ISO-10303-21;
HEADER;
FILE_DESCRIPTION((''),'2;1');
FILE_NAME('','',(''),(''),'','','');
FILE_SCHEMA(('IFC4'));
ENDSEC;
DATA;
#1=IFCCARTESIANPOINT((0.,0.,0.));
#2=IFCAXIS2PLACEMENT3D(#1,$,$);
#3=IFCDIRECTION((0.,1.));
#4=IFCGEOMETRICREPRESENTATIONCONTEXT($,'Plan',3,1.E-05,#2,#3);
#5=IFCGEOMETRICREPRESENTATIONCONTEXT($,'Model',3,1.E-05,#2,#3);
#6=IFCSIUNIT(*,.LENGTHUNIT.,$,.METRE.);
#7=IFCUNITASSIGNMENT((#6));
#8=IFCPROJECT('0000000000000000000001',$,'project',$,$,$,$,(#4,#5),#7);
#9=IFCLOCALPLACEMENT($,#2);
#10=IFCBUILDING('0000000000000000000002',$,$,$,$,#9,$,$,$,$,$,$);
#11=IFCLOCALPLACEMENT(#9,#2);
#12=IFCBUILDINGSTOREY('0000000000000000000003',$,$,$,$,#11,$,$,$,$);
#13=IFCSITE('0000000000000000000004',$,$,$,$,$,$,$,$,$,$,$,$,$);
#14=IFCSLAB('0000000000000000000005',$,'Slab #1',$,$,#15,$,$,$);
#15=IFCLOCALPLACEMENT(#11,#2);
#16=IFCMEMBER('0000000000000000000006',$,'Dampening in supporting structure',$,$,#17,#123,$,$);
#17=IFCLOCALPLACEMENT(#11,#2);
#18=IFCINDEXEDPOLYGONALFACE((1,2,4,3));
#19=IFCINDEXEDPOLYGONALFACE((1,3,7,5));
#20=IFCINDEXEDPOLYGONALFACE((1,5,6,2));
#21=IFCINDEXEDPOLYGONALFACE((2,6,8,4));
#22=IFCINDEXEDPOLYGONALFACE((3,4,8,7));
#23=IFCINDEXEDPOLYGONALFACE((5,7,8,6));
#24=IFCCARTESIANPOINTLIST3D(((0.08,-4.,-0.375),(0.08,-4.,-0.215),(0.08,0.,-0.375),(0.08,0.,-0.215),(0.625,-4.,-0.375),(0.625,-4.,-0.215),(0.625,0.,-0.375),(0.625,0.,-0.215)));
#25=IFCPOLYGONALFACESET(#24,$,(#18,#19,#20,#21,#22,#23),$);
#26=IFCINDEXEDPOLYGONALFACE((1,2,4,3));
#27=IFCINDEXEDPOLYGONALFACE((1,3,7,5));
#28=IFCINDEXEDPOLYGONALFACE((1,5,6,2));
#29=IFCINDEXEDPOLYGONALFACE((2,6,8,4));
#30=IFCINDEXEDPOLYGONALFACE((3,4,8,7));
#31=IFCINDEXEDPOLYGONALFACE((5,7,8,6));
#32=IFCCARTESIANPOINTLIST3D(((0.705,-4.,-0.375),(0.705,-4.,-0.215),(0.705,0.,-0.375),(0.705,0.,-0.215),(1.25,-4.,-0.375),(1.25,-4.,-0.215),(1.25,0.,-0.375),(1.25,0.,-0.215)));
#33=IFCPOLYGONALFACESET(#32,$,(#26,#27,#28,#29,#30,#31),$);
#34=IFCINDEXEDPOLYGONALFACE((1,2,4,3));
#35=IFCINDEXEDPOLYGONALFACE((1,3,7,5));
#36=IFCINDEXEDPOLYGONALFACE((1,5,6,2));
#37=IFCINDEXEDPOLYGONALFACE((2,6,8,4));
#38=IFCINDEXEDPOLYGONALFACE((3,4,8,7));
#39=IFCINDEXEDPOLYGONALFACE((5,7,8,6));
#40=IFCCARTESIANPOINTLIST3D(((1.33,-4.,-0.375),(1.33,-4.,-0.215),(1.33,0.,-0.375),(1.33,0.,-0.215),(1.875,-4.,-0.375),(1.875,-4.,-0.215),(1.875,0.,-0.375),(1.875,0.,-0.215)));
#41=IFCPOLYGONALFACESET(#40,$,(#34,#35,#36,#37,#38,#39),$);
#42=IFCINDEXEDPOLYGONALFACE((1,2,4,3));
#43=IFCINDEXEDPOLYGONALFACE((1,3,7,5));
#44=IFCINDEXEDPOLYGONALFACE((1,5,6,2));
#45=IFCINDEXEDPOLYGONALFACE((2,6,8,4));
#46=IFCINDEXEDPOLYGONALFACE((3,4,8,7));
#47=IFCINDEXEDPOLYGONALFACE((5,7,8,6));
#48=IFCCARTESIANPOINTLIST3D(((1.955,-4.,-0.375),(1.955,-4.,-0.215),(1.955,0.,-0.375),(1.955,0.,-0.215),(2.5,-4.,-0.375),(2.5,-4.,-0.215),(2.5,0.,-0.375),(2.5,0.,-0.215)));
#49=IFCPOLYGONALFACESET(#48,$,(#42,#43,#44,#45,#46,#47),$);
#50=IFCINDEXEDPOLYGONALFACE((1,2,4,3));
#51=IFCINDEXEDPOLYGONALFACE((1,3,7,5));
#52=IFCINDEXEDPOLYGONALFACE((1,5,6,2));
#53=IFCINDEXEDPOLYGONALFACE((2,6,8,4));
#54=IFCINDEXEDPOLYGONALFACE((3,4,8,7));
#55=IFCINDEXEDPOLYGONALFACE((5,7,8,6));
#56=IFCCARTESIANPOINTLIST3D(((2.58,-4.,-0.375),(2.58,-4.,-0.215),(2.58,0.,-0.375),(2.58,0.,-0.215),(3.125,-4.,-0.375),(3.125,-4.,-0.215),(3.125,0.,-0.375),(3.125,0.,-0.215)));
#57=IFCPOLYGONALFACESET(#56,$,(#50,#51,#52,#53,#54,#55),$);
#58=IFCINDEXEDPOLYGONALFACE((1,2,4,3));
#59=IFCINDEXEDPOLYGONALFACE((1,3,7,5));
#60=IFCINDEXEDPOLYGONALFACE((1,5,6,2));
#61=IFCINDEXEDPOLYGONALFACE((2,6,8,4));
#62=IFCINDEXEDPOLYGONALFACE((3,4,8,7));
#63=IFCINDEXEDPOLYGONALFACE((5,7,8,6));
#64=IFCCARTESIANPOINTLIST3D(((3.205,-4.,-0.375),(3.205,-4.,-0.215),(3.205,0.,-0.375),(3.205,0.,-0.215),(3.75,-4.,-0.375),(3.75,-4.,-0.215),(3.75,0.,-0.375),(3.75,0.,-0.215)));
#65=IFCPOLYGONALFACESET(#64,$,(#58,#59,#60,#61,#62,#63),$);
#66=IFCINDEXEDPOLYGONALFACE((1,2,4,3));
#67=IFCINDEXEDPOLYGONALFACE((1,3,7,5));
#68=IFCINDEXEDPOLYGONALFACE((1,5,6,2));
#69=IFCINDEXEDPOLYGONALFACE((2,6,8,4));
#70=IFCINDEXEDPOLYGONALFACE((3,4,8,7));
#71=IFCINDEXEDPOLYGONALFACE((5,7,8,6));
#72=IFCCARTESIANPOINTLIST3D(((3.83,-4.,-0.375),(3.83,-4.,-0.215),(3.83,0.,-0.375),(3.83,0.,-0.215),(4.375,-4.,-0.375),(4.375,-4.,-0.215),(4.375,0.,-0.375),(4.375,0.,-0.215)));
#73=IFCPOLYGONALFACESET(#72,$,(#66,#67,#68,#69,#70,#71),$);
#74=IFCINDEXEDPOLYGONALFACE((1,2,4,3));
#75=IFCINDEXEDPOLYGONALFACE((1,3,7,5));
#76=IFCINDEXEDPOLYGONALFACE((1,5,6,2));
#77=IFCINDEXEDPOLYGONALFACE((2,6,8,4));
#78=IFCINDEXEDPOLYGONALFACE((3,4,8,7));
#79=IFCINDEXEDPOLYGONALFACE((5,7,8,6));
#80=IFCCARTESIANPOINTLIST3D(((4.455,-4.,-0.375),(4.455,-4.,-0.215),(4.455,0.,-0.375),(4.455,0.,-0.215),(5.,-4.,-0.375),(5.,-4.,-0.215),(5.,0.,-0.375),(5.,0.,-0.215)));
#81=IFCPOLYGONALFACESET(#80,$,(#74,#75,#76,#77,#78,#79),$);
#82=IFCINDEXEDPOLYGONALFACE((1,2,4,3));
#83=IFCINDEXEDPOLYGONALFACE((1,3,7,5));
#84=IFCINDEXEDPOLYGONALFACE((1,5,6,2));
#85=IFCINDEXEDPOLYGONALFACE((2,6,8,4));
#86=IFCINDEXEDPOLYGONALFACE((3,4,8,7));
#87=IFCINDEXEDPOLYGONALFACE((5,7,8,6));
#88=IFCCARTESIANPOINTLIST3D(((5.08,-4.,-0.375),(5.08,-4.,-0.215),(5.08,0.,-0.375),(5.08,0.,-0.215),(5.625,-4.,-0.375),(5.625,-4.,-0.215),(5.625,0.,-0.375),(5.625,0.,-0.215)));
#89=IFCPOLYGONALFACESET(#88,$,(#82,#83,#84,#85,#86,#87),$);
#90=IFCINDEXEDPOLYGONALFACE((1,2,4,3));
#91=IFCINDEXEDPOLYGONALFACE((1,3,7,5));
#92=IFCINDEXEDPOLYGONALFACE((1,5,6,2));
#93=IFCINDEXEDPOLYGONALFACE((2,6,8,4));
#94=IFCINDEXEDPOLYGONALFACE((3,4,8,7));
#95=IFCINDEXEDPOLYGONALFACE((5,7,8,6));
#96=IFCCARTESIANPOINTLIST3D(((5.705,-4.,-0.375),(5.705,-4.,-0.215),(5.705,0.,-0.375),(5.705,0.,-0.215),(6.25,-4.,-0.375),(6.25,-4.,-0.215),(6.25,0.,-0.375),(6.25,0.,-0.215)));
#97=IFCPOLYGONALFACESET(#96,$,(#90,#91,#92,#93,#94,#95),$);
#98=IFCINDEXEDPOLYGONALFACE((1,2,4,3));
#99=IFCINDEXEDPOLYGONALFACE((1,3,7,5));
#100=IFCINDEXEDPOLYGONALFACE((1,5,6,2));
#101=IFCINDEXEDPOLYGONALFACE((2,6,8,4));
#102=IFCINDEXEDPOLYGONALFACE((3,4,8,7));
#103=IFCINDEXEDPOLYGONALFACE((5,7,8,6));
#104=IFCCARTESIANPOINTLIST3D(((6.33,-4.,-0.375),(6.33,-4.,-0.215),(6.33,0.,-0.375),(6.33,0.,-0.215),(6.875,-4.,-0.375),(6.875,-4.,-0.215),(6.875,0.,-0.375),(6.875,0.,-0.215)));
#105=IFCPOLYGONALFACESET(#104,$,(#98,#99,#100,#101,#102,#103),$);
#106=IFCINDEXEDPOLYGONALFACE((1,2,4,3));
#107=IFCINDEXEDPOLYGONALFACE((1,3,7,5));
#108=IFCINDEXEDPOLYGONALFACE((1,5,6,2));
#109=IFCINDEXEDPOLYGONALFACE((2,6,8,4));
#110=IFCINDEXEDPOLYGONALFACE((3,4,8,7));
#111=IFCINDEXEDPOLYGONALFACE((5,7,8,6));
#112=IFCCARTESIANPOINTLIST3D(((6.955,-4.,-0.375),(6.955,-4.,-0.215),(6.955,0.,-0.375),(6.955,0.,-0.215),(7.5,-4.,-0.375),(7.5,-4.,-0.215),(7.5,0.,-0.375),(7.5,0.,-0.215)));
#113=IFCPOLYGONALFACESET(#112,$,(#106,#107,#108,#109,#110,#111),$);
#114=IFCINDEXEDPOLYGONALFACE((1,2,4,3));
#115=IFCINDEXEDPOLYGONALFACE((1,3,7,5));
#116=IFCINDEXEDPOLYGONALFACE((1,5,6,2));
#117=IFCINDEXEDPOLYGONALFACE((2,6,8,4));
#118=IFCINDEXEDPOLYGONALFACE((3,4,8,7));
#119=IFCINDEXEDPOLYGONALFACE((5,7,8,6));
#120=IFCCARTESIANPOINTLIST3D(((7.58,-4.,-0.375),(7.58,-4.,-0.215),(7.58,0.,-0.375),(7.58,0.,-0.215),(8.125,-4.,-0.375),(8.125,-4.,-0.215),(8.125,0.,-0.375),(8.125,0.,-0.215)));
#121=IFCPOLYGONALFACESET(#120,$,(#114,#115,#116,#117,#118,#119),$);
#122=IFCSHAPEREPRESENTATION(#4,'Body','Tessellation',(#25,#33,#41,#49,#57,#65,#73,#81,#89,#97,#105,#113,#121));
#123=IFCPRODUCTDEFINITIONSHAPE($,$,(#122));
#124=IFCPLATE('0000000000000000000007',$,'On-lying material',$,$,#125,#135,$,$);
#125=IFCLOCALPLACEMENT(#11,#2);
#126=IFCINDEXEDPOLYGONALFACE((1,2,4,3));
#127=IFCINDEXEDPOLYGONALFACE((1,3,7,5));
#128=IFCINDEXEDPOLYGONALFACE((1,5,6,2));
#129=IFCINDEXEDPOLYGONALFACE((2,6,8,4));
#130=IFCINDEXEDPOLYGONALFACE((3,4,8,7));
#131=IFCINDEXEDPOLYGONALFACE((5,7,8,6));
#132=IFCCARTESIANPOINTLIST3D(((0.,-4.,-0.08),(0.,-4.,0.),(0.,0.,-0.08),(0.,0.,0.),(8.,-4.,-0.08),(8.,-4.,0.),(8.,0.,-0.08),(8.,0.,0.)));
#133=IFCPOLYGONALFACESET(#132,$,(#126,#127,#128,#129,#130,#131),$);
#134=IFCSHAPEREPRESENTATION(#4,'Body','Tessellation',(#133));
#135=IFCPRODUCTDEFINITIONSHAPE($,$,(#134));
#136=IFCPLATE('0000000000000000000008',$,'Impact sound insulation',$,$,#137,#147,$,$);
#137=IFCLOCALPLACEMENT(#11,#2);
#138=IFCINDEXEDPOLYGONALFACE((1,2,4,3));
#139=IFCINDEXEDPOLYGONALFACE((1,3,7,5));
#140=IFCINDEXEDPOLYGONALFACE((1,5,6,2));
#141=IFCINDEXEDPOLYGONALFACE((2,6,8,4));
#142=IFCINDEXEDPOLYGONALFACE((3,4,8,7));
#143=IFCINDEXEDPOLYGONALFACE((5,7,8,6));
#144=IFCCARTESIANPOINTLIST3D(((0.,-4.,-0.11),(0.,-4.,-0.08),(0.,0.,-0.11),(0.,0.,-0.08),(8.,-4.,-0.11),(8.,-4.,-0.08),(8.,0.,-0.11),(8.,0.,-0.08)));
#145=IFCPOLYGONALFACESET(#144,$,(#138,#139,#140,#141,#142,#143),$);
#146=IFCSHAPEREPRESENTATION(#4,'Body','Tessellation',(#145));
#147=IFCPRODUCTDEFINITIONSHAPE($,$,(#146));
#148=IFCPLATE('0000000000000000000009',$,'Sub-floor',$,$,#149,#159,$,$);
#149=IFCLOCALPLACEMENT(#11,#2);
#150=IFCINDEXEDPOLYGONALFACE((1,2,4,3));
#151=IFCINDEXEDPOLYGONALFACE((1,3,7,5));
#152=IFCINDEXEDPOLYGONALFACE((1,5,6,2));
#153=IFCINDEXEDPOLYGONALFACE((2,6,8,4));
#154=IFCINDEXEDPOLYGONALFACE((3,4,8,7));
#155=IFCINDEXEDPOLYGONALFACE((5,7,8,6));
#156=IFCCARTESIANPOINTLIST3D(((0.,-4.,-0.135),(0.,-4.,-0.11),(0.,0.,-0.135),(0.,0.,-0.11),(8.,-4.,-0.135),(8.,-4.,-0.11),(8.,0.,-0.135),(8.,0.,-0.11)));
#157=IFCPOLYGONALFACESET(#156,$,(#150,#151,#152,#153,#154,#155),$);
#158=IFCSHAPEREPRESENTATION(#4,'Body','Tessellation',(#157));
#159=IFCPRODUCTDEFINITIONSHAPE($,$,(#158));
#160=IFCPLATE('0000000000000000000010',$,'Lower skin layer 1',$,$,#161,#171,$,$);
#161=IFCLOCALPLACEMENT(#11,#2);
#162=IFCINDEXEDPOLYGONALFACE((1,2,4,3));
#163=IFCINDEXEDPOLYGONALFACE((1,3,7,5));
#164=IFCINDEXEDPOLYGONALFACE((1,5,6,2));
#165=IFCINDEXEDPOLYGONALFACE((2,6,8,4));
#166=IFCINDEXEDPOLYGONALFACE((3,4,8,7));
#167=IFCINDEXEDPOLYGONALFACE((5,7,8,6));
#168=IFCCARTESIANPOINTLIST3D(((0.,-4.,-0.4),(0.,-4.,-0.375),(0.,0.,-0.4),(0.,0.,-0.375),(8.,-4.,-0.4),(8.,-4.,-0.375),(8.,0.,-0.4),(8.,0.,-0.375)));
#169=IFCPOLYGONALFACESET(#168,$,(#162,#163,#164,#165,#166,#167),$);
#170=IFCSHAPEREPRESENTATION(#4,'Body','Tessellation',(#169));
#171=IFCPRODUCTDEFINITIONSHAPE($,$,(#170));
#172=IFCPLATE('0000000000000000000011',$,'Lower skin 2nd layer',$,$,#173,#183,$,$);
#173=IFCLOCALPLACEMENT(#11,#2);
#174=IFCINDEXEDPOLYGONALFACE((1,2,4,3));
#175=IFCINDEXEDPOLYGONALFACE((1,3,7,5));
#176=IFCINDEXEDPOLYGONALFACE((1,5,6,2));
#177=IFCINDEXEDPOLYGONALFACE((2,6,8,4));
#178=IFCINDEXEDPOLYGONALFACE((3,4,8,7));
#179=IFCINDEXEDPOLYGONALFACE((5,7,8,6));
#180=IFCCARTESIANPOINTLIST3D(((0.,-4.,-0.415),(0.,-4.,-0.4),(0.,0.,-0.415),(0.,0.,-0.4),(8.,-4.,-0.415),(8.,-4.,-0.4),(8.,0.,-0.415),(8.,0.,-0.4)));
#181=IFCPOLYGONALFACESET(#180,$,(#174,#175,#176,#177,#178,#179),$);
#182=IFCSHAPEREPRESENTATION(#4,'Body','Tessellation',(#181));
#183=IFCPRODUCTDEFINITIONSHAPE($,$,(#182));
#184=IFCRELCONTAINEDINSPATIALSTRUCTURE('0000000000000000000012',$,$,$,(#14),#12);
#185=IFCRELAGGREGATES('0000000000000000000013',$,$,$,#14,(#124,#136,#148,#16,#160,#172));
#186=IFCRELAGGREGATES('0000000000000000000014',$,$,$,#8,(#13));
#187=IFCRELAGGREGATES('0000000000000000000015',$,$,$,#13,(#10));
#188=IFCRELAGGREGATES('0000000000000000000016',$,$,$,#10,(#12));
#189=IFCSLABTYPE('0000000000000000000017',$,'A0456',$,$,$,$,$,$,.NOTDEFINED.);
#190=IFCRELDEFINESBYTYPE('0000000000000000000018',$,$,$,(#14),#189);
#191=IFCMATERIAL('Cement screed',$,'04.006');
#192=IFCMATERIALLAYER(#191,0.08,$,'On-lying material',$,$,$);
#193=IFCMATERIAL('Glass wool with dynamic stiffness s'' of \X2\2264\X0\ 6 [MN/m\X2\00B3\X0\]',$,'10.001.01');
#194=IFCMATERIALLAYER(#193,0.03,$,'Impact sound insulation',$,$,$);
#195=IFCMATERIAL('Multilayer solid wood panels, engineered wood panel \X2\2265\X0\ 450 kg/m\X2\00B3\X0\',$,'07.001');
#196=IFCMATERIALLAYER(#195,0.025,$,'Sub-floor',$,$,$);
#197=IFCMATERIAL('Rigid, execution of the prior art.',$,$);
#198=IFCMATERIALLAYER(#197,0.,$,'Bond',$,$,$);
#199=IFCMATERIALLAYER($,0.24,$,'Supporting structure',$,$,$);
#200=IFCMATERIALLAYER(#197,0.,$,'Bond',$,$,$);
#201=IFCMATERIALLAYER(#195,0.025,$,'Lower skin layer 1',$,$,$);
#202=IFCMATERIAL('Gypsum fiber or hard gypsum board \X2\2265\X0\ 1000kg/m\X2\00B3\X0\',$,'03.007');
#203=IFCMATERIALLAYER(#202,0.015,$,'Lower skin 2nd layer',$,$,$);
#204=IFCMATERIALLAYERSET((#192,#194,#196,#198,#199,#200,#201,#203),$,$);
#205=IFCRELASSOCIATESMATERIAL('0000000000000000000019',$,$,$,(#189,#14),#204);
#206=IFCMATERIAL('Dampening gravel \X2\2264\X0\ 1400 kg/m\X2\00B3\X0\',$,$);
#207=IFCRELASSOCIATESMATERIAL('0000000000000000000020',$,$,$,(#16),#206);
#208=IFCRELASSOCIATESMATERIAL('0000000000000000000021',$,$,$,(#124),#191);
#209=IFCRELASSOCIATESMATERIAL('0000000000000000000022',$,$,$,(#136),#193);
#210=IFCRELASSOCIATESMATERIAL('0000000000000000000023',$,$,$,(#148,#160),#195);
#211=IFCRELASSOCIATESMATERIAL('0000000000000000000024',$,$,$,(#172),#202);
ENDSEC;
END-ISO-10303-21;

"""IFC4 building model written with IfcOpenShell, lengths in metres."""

from ifc_helpers import new_model, si_unit, direction, frame, frame_2d, origin, origin_with_axes, place, context, project, spatial, rectangle, extrude, material, layer, layer_set, type_object, element, aggregate, save


model = new_model("IFC4")

# Units and contexts
plan_context = context("Plan", 3, precision=1e-05, world=origin(), true_north=direction((0.0, 1.0)))
model_context = context("Model", 3, precision=1e-05, world=origin(), true_north=direction((0.0, 1.0)))
ifc_project = project(units=[si_unit("LENGTHUNIT", "METRE")], contexts=[plan_context, model_context])

# Site, building, storey
site = spatial("IfcSite", under=ifc_project)
building_placement = place(None, origin())
building = spatial("IfcBuilding", under=site, at=building_placement)
storey_placement = place(building_placement, origin())
storey = spatial("IfcBuildingStorey", under=building, at=storey_placement)

# Slab, member, plates
ifc_material_1 = material(Name="Cement screed", Category="04.006")
ifc_layer_1 = layer(ifc_material_1, 0.08, Name="On-lying material")
ifc_material_2 = material(Name="Glass wool with dynamic stiffness s' of ≤ 6 [MN/m³]", Category="10.001.01")
ifc_layer_2 = layer(ifc_material_2, 0.03, Name="Impact sound insulation")
ifc_material_3 = material(Name="Multilayer solid wood panels, engineered wood panel ≥ 450 kg/m³", Category="07.001")
ifc_layer_3 = layer(ifc_material_3, 0.025, Name="Sub-floor")
ifc_material_4 = material(Name="Rigid, execution of the prior art.")
ifc_layer_4 = layer(ifc_material_4, 0.0, Name="Bond")
ifc_layer_5 = layer(None, 0.24, Name="Supporting structure")
ifc_layer_6 = layer(ifc_material_4, 0.0, Name="Bond")
ifc_layer_7 = layer(ifc_material_3, 0.025, Name="Lower skin layer 1")
ifc_material_5 = material(Name="Gypsum fiber or hard gypsum board ≥ 1000kg/m³", Category="03.007")
ifc_layer_8 = layer(ifc_material_5, 0.015, Name="Lower skin 2nd layer")
ifc_layer_set = layer_set([ifc_layer_1, ifc_layer_2, ifc_layer_3, ifc_layer_4, ifc_layer_5, ifc_layer_6, ifc_layer_7, ifc_layer_8])
slab_type = type_object("IfcSlabType", Name="A0456", PredefinedType="NOTDEFINED", material=ifc_layer_set)
slab_placement = place(None, frame((0.0, 0.0, 0.0), z_axis=(0.0, 0.0, -1.0), x_axis=(1.0, 0.0, 0.0)))
slab = element("IfcSlab", 1, at=slab_placement, inside=storey, type_object=slab_type, material=ifc_layer_set, Name="Slab #1")
ifc_material_6 = material(Name="Dampening gravel ≤ 1400 kg/m³")
member_1_placement = place(slab_placement, origin())
member_1 = element("IfcMember", 2, at=member_1_placement, material=ifc_material_6, Name="Dampening in supporting structure", context=plan_context, shape_type="SweptSolid", body=[
    extrude(rectangle(XDim=0.545, YDim=0.16, at=frame_2d((0.2725, 0.08), x_axis=(1.0, 0.0))), frame((0.08, 4.0, 0.215), z_axis=(0.0, -1.0, 0.0), x_axis=(1.0, 0.0, 0.0)), (0.0, 0.0, 1.0), 4.0),
    extrude(rectangle(XDim=0.545, YDim=0.16, at=frame_2d((0.2725, 0.08), x_axis=(1.0, 0.0))), frame((0.705, 4.0, 0.215), z_axis=(0.0, -1.0, 0.0), x_axis=(1.0, 0.0, 0.0)), (0.0, 0.0, 1.0), 4.0),
    extrude(rectangle(XDim=0.545, YDim=0.16, at=frame_2d((0.2725, 0.08), x_axis=(1.0, 0.0))), frame((1.33, 4.0, 0.215), z_axis=(0.0, -1.0, 0.0), x_axis=(1.0, 0.0, 0.0)), (0.0, 0.0, 1.0), 4.0),
    extrude(rectangle(XDim=0.545, YDim=0.16, at=frame_2d((0.2725, 0.08), x_axis=(1.0, 0.0))), frame((1.955, 4.0, 0.215), z_axis=(0.0, -1.0, 0.0), x_axis=(1.0, 0.0, 0.0)), (0.0, 0.0, 1.0), 4.0),
    extrude(rectangle(XDim=0.545, YDim=0.16, at=frame_2d((0.2725, 0.08), x_axis=(1.0, 0.0))), frame((2.58, 4.0, 0.215), z_axis=(0.0, -1.0, 0.0), x_axis=(1.0, 0.0, 0.0)), (0.0, 0.0, 1.0), 4.0),
    extrude(rectangle(XDim=0.545, YDim=0.16, at=frame_2d((0.2725, 0.08), x_axis=(1.0, 0.0))), frame((3.205, 4.0, 0.215), z_axis=(0.0, -1.0, 0.0), x_axis=(1.0, 0.0, 0.0)), (0.0, 0.0, 1.0), 4.0),
    extrude(rectangle(XDim=0.545, YDim=0.16, at=frame_2d((0.2725, 0.08), x_axis=(1.0, 0.0))), frame((3.83, 4.0, 0.215), z_axis=(0.0, -1.0, 0.0), x_axis=(1.0, 0.0, 0.0)), (0.0, 0.0, 1.0), 4.0),
    extrude(rectangle(XDim=0.545, YDim=0.16, at=frame_2d((0.2725, 0.08), x_axis=(1.0, 0.0))), frame((4.455, 4.0, 0.215), z_axis=(0.0, -1.0, 0.0), x_axis=(1.0, 0.0, 0.0)), (0.0, 0.0, 1.0), 4.0),
    extrude(rectangle(XDim=0.545, YDim=0.16, at=frame_2d((0.2725, 0.08), x_axis=(1.0, 0.0))), frame((5.08, 4.0, 0.215), z_axis=(0.0, -1.0, 0.0), x_axis=(1.0, 0.0, 0.0)), (0.0, 0.0, 1.0), 4.0),
    extrude(rectangle(XDim=0.545, YDim=0.16, at=frame_2d((0.2725, 0.08), x_axis=(1.0, 0.0))), frame((5.705, 4.0, 0.215), z_axis=(0.0, -1.0, 0.0), x_axis=(1.0, 0.0, 0.0)), (0.0, 0.0, 1.0), 4.0),
    extrude(rectangle(XDim=0.545, YDim=0.16, at=frame_2d((0.2725, 0.08), x_axis=(1.0, 0.0))), frame((6.33, 4.0, 0.215), z_axis=(0.0, -1.0, 0.0), x_axis=(1.0, 0.0, 0.0)), (0.0, 0.0, 1.0), 4.0),
    extrude(rectangle(XDim=0.545, YDim=0.16, at=frame_2d((0.2725, 0.08), x_axis=(1.0, 0.0))), frame((6.955, 4.0, 0.215), z_axis=(0.0, -1.0, 0.0), x_axis=(1.0, 0.0, 0.0)), (0.0, 0.0, 1.0), 4.0),
    extrude(rectangle(XDim=0.545, YDim=0.16, at=frame_2d((0.2725, 0.08), x_axis=(1.0, 0.0))), frame((7.58, 4.0, 0.215), z_axis=(0.0, -1.0, 0.0), x_axis=(1.0, 0.0, 0.0)), (0.0, 0.0, 1.0), 4.0),
])
plate_1_placement = place(slab_placement, origin())
plate_1 = element("IfcPlate", 3, at=plate_1_placement, material=ifc_material_1, Name="On-lying material", context=plan_context, shape_type="SweptSolid", body=[
    extrude(rectangle(XDim=8.0, YDim=4.0, at=frame_2d((4.0, 2.0), x_axis=(1.0, 0.0))), origin_with_axes(), (0.0, 0.0, 1.0), 0.08),
])
plate_2_placement = place(slab_placement, origin())
plate_2 = element("IfcPlate", 4, at=plate_2_placement, material=ifc_material_2, Name="Impact sound insulation", context=plan_context, shape_type="SweptSolid", body=[
    extrude(rectangle(XDim=8.0, YDim=4.0, at=frame_2d((4.0, 2.0), x_axis=(1.0, 0.0))), frame((0.0, 0.0, 0.08), z_axis=(0.0, 0.0, 1.0), x_axis=(1.0, 0.0, 0.0)), (0.0, 0.0, 1.0), 0.03),
])
plate_3_placement = place(slab_placement, origin())
plate_3 = element("IfcPlate", 5, at=plate_3_placement, material=ifc_material_3, Name="Sub-floor", context=plan_context, shape_type="SweptSolid", body=[
    extrude(rectangle(XDim=8.0, YDim=4.0, at=frame_2d((4.0, 2.0), x_axis=(1.0, 0.0))), frame((0.0, 0.0, 0.11), z_axis=(0.0, 0.0, 1.0), x_axis=(1.0, 0.0, 0.0)), (0.0, 0.0, 1.0), 0.025),
])
plate_4_placement = place(slab_placement, origin())
plate_4 = element("IfcPlate", 6, at=plate_4_placement, material=ifc_material_3, Name="Lower skin layer 1", context=plan_context, shape_type="SweptSolid", body=[
    extrude(rectangle(XDim=8.0, YDim=4.0, at=frame_2d((4.0, 2.0), x_axis=(1.0, 0.0))), frame((0.0, 0.0, 0.375), z_axis=(0.0, 0.0, 1.0), x_axis=(1.0, 0.0, 0.0)), (0.0, 0.0, 1.0), 0.025),
])
plate_5_placement = place(slab_placement, origin())
plate_5 = element("IfcPlate", 7, at=plate_5_placement, material=ifc_material_5, Name="Lower skin 2nd layer", context=plan_context, shape_type="SweptSolid", body=[
    extrude(rectangle(XDim=8.0, YDim=4.0, at=frame_2d((4.0, 2.0), x_axis=(1.0, 0.0))), frame((0.0, 0.0, 0.4), z_axis=(0.0, 0.0, 1.0), x_axis=(1.0, 0.0, 0.0)), (0.0, 0.0, 1.0), 0.015),
])
aggregate(slab, [plate_1, plate_2, plate_3, member_1, plate_4, plate_5])

save(model, "model.ifc")
